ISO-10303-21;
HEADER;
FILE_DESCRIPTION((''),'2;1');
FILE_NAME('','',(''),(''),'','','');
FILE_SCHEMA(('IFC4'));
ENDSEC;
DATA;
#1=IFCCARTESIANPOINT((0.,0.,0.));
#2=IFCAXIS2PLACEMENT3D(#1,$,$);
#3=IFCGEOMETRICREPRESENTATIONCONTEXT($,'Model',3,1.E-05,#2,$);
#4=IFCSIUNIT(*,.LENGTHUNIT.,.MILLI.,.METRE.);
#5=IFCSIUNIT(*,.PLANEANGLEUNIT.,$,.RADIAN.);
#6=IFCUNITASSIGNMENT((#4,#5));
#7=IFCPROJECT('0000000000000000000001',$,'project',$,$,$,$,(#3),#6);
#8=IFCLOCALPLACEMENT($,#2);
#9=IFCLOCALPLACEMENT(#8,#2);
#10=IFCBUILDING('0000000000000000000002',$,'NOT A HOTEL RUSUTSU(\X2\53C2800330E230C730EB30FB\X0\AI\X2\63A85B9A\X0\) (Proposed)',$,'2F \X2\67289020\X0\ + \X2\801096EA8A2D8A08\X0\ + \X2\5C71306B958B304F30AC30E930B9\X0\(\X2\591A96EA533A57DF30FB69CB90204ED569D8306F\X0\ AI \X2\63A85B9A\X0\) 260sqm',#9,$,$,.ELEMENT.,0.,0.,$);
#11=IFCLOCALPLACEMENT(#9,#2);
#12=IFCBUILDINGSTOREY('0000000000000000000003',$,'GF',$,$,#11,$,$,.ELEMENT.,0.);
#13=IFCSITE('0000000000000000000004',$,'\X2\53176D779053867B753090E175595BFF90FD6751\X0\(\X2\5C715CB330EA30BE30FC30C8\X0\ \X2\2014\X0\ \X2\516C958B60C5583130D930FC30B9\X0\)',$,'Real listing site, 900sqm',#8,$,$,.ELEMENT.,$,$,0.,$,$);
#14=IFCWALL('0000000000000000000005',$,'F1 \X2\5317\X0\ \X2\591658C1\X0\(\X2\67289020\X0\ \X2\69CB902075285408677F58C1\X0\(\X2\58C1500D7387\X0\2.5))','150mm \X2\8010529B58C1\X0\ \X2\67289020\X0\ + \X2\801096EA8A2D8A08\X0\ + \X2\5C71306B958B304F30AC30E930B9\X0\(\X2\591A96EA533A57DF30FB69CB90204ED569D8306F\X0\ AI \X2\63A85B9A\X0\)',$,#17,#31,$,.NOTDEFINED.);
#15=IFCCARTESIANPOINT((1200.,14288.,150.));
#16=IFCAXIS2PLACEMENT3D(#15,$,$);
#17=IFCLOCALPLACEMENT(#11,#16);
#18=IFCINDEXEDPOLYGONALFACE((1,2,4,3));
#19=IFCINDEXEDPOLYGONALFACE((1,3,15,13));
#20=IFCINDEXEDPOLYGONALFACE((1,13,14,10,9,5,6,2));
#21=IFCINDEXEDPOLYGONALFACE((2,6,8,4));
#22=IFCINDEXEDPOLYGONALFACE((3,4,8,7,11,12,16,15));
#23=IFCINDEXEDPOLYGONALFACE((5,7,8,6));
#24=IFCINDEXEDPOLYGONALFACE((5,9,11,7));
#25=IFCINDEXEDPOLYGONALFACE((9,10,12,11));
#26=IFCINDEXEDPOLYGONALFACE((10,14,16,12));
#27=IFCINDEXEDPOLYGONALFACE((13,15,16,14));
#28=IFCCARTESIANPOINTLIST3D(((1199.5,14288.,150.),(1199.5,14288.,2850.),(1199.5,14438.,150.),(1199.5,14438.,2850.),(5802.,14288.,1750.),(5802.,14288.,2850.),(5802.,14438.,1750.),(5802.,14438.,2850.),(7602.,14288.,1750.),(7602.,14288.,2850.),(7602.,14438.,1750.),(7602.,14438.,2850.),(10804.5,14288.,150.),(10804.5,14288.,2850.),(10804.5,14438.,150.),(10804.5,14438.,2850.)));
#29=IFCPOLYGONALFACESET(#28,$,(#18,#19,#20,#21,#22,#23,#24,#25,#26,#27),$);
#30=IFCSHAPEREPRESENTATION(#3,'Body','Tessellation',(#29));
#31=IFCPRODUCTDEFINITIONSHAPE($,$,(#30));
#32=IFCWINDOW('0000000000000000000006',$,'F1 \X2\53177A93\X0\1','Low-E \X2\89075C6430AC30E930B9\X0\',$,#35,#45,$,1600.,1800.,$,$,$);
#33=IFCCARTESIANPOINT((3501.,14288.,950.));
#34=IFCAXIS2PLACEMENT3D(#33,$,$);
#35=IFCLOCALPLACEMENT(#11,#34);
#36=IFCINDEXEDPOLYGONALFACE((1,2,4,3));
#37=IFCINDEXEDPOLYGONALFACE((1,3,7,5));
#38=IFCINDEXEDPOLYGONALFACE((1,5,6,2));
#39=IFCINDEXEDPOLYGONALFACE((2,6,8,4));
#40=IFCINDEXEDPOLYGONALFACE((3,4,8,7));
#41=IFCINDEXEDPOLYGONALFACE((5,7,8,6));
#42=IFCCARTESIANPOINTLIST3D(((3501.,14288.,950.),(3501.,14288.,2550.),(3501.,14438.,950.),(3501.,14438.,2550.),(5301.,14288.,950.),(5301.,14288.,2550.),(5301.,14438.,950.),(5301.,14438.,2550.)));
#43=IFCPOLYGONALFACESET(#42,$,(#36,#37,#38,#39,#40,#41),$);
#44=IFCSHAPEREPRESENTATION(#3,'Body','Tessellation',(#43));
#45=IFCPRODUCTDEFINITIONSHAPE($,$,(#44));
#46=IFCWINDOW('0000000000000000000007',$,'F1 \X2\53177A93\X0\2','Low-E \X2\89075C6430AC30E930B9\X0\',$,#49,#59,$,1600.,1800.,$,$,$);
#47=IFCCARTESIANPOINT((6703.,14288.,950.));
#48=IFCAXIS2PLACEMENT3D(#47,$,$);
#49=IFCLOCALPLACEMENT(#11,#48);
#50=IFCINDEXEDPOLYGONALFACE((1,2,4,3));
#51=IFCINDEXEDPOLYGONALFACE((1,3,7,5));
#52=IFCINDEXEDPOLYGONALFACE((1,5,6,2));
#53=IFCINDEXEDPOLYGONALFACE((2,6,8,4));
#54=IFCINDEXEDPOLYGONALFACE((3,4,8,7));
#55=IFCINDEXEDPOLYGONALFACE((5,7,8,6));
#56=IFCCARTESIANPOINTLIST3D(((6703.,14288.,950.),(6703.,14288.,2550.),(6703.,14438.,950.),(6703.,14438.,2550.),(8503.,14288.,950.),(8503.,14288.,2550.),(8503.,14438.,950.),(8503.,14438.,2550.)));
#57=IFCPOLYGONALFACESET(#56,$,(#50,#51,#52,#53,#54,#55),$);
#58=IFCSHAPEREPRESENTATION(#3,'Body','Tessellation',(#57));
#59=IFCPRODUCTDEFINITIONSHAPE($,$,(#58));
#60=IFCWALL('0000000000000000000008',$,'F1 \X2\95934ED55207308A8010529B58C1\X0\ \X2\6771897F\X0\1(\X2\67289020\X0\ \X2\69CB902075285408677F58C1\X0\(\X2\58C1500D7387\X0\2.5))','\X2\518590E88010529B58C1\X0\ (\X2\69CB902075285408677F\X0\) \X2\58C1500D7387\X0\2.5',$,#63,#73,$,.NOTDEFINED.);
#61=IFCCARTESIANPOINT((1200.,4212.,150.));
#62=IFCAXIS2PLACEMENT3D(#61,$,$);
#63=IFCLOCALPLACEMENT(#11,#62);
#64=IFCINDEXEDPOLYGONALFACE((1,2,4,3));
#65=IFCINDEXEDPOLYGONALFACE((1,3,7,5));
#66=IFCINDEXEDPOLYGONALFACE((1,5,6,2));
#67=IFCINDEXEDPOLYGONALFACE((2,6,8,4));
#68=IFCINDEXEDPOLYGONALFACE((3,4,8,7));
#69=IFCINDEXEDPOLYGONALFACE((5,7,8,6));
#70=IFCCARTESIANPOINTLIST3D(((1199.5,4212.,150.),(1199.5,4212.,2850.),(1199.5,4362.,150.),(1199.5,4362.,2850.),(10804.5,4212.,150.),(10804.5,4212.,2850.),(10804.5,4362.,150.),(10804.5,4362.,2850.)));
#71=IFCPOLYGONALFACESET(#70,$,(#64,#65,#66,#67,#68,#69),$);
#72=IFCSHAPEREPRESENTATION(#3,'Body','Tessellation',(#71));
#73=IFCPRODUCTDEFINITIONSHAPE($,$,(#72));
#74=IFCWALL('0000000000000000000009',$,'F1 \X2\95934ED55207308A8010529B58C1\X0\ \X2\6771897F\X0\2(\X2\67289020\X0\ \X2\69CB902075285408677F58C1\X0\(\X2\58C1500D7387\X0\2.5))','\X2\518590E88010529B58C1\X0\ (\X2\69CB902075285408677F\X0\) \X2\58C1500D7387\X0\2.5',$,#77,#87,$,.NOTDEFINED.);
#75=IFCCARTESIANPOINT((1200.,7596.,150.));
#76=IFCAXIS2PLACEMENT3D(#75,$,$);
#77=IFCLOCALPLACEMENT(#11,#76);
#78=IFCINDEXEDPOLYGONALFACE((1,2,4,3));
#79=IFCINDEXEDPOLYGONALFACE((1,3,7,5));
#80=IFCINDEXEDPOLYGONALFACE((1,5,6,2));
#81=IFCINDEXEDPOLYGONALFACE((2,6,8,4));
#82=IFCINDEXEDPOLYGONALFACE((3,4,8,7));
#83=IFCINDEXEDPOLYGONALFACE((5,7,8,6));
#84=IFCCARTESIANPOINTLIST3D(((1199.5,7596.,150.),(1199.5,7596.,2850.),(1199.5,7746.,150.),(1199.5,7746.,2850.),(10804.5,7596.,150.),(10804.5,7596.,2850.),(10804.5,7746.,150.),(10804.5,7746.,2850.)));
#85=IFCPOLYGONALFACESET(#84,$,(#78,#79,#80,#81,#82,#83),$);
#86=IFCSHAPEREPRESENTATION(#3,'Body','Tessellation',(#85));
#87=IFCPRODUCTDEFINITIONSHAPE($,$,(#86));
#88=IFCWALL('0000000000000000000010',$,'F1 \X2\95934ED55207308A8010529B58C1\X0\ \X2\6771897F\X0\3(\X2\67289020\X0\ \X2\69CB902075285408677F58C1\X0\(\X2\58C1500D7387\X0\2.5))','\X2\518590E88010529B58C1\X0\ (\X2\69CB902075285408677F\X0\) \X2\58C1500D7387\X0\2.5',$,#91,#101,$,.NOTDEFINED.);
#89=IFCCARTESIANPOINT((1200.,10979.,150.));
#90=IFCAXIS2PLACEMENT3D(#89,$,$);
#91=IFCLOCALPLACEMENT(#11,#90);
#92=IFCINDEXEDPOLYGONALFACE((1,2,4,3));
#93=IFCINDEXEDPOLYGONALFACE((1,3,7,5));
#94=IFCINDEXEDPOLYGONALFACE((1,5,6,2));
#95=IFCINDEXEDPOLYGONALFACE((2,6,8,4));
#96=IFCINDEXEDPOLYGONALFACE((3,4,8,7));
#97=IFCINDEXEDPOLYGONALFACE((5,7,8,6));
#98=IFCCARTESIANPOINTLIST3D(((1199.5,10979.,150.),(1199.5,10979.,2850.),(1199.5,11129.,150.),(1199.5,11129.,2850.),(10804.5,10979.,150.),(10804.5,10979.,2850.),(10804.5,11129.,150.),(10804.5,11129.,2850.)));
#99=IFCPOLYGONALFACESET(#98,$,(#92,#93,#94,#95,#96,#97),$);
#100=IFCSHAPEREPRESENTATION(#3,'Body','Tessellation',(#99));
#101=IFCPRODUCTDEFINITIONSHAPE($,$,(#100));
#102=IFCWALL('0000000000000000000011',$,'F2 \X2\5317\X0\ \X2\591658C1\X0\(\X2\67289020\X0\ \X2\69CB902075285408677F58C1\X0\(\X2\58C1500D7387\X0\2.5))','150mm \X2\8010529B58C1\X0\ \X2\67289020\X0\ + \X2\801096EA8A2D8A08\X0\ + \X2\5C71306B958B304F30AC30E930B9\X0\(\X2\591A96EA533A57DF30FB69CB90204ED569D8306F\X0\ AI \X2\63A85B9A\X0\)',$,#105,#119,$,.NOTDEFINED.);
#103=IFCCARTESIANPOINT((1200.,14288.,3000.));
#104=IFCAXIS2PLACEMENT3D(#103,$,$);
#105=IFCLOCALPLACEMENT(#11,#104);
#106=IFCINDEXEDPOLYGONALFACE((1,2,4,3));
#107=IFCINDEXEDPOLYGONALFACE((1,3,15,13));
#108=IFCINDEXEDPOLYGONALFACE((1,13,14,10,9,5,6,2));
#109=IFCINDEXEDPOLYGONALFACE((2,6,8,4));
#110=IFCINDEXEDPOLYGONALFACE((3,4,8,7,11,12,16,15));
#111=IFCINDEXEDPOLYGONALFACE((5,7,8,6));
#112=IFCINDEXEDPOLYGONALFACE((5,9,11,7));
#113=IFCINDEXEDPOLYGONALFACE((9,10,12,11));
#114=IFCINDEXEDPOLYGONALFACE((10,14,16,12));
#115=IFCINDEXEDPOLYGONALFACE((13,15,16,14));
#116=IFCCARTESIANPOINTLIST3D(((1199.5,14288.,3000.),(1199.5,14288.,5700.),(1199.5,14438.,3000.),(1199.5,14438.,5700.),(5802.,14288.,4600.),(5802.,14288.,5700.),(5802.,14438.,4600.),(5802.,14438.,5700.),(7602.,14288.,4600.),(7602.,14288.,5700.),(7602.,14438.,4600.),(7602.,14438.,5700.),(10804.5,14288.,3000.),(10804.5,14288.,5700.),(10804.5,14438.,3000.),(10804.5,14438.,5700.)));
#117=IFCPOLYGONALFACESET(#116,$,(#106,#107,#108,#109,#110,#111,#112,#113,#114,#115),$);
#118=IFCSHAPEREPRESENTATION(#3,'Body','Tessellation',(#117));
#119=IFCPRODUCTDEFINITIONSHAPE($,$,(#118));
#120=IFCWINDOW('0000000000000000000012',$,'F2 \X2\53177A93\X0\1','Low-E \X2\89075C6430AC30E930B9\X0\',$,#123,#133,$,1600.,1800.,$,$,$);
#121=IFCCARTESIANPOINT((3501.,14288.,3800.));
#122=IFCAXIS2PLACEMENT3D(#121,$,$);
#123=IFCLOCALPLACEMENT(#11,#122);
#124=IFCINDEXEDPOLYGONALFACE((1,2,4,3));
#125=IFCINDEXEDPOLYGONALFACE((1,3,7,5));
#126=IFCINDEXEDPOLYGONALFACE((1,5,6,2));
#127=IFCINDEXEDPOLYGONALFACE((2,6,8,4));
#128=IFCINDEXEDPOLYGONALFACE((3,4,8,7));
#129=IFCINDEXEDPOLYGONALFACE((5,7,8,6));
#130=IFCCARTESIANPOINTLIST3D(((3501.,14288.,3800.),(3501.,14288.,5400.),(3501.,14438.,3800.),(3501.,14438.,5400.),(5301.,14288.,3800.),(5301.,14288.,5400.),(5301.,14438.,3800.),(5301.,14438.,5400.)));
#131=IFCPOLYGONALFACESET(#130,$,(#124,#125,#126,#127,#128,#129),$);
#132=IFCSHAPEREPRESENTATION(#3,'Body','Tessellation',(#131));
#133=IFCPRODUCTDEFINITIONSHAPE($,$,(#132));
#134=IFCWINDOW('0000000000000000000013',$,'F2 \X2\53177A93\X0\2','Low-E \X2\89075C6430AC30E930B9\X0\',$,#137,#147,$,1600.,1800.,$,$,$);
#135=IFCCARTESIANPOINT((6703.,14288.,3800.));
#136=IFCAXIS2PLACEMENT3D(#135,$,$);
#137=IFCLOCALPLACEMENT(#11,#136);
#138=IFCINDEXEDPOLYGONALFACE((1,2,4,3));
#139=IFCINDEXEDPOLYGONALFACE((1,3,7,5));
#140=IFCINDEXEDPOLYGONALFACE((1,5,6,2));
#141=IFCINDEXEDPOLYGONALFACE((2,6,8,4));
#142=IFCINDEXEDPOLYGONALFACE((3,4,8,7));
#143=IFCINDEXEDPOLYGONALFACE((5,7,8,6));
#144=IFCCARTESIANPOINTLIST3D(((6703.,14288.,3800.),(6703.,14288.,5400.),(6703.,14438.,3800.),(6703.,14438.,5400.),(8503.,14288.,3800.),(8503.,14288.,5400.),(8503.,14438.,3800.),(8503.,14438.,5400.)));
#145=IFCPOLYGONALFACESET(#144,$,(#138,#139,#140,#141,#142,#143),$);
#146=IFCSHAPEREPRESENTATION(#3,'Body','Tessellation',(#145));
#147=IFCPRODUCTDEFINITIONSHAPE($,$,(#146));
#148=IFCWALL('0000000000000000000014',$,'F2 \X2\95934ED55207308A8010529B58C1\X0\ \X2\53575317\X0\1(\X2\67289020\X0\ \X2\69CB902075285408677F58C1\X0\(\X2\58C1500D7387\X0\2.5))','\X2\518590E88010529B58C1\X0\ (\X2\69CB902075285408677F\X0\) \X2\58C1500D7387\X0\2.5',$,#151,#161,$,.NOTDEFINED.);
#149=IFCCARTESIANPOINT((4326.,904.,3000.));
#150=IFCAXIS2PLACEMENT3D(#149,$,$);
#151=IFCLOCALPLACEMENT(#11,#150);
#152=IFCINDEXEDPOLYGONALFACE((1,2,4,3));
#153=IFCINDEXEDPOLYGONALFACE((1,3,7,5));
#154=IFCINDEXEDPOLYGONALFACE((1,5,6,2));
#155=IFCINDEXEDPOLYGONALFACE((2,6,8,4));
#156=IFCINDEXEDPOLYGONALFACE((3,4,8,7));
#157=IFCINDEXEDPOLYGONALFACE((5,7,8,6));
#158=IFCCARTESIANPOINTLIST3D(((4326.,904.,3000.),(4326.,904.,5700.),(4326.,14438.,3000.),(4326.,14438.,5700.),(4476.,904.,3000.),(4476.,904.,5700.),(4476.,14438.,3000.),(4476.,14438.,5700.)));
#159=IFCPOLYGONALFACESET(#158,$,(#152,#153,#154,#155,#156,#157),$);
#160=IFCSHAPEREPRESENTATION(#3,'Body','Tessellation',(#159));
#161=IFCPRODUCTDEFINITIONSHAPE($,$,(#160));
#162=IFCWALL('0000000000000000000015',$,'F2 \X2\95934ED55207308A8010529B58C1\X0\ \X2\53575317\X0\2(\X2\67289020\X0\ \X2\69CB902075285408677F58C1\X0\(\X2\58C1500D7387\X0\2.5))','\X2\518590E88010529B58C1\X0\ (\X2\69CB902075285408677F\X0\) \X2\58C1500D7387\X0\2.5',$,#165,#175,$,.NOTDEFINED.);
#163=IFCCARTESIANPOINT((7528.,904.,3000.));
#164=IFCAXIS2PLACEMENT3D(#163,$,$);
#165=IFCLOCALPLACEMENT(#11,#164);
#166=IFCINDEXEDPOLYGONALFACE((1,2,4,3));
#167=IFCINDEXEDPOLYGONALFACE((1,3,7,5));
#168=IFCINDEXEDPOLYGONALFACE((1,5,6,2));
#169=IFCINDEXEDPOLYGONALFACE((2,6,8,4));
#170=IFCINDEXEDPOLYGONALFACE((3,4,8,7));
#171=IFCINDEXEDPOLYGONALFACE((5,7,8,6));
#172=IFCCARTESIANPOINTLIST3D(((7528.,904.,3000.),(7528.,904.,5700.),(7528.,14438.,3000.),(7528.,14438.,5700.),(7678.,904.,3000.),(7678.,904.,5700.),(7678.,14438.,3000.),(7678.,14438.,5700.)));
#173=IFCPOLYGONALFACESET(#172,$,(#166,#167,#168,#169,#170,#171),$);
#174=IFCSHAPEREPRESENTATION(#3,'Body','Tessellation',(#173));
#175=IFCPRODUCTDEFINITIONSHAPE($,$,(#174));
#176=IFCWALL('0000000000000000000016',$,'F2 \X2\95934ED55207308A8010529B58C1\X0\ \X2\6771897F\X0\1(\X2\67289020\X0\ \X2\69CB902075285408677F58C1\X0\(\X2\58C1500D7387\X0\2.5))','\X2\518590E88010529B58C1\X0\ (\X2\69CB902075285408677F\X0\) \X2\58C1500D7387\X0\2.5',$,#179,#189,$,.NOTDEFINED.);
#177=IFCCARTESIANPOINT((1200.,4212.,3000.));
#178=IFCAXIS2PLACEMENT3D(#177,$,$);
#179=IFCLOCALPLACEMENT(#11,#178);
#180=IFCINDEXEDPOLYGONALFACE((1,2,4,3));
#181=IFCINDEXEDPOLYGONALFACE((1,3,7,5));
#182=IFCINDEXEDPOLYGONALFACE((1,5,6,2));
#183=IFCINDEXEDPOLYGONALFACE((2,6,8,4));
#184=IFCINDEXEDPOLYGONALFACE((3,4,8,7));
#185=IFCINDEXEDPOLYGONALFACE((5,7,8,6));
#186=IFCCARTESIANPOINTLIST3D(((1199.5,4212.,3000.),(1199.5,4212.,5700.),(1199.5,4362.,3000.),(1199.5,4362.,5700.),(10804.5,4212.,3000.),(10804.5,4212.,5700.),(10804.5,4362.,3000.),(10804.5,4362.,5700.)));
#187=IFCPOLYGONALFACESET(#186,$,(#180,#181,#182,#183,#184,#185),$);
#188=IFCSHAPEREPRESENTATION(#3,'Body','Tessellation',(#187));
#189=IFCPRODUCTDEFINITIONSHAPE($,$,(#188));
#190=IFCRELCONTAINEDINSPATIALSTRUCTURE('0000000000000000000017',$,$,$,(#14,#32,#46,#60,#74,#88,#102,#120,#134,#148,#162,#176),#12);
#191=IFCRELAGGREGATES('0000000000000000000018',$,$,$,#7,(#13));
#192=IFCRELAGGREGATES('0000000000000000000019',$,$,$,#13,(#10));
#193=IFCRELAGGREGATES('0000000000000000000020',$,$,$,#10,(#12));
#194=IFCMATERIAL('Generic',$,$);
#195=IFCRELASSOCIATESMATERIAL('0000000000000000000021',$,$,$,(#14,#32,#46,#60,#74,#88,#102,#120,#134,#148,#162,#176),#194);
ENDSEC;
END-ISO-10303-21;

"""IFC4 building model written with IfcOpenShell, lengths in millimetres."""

from ifc_helpers import new_model, si_unit, frame, frame_2d, origin, place, context, project, spatial, rectangle, extrude, material, element, fill, save


model = new_model("IFC4")

# Units and contexts
model_context = context("Model", 3, precision=1e-05, world=origin())
ifc_project = project(units=[si_unit("LENGTHUNIT", "METRE", prefix="MILLI"), si_unit("PLANEANGLEUNIT", "RADIAN")], contexts=[model_context])

# Site, building, storey
site_placement = place(None, origin())
site = spatial("IfcSite", under=ifc_project, at=site_placement, Name="北海道虻田郡留寿都村(山岳リゾート — 公開情報ベース)", ObjectType="Real listing site, 900sqm", CompositionType="ELEMENT", RefElevation=0.0)
building_placement = place(site_placement, origin())
building = spatial("IfcBuilding", under=site, at=building_placement, Name="NOT A HOTEL RUSUTSU(参考モデル・AI推定) (Proposed)", ObjectType="2F 木造 + 耐雪設計 + 山に開くガラス(多雪区域・構造仕様は AI 推定) 260sqm", CompositionType="ELEMENT", ElevationOfRefHeight=0.0, ElevationOfTerrain=0.0)
storey_placement = place(building_placement, origin())
storey = spatial("IfcBuildingStorey", under=building, at=storey_placement, Name="GF", CompositionType="ELEMENT", Elevation=0.0)

# Wall, openings, windows
ifc_material_1 = material(Name="Generic")
wall_1_placement = place(storey_placement, frame((1200.0, 14288.0, 150.0)))
wall_1 = element("IfcWall", 1, at=wall_1_placement, inside=storey, material=ifc_material_1, Name="F1 北 外壁(木造 構造用合板壁(壁倍率2.5))", Description="150mm 耐力壁 木造 + 耐雪設計 + 山に開くガラス(多雪区域・構造仕様は AI 推定)", PredefinedType="NOTDEFINED", context=model_context, shape_type="SweptSolid", body=[
    extrude(rectangle(XDim=9605.0, YDim=150.0, at=frame_2d((4802.0, 75.0))), frame((1200.0, 14288.0, 150.0)), (0.0, 0.0, 1.0), 2700.0),
])
opening_1_placement = place(storey_placement, frame((3501.0, 14288.0, 950.0)))
opening_1 = element("IfcOpeningElement", 2, at=opening_1_placement, cuts=wall_1, PredefinedType="NOTDEFINED", context=model_context, shape_type="SweptSolid", body=[
    extrude(rectangle(XDim=1800.0, YDim=150.0, at=frame_2d((900.0, 75.0))), frame((3501.0, 14288.0, 950.0)), (0.0, 0.0, 1.0), 1600.0),
])
opening_2_placement = place(storey_placement, frame((6703.0, 14288.0, 950.0)))
opening_2 = element("IfcOpeningElement", 3, at=opening_2_placement, cuts=wall_1, PredefinedType="NOTDEFINED", context=model_context, shape_type="SweptSolid", body=[
    extrude(rectangle(XDim=1800.0, YDim=150.0, at=frame_2d((900.0, 75.0))), frame((6703.0, 14288.0, 950.0)), (0.0, 0.0, 1.0), 1600.0),
])
window_1_placement = place(storey_placement, frame((3501.0, 14288.0, 950.0)))
window_1 = element("IfcWindow", 4, at=window_1_placement, inside=storey, material=ifc_material_1, Name="F1 北窓1", Description="Low-E 複層ガラス", OverallHeight=1600.0, OverallWidth=1800.0, context=model_context, shape_type="SweptSolid", body=[
    extrude(rectangle(XDim=1800.0, YDim=150.0, at=frame_2d((900.0, 75.0))), frame((3501.0, 14288.0, 950.0)), (0.0, 0.0, 1.0), 1600.0),
])
fill(opening_1, window_1)
window_2_placement = place(storey_placement, frame((6703.0, 14288.0, 950.0)))
window_2 = element("IfcWindow", 5, at=window_2_placement, inside=storey, material=ifc_material_1, Name="F1 北窓2", Description="Low-E 複層ガラス", OverallHeight=1600.0, OverallWidth=1800.0, context=model_context, shape_type="SweptSolid", body=[
    extrude(rectangle(XDim=1800.0, YDim=150.0, at=frame_2d((900.0, 75.0))), frame((6703.0, 14288.0, 950.0)), (0.0, 0.0, 1.0), 1600.0),
])
fill(opening_2, window_2)

# Walls
wall_2_placement = place(storey_placement, frame((1200.0, 4212.0, 150.0)))
element("IfcWall", 6, at=wall_2_placement, inside=storey, material=ifc_material_1, Name="F1 間仕切り耐力壁 東西1(木造 構造用合板壁(壁倍率2.5))", Description="内部耐力壁 (構造用合板) 壁倍率2.5", PredefinedType="NOTDEFINED", context=model_context, shape_type="SweptSolid", body=[
    extrude(rectangle(XDim=9605.0, YDim=150.0, at=frame_2d((4802.0, 75.0))), frame((1200.0, 4212.0, 150.0)), (0.0, 0.0, 1.0), 2700.0),
])
wall_3_placement = place(storey_placement, frame((1200.0, 7596.0, 150.0)))
element("IfcWall", 7, at=wall_3_placement, inside=storey, material=ifc_material_1, Name="F1 間仕切り耐力壁 東西2(木造 構造用合板壁(壁倍率2.5))", Description="内部耐力壁 (構造用合板) 壁倍率2.5", PredefinedType="NOTDEFINED", context=model_context, shape_type="SweptSolid", body=[
    extrude(rectangle(XDim=9605.0, YDim=150.0, at=frame_2d((4802.0, 75.0))), frame((1200.0, 7596.0, 150.0)), (0.0, 0.0, 1.0), 2700.0),
])
wall_4_placement = place(storey_placement, frame((1200.0, 10979.0, 150.0)))
element("IfcWall", 8, at=wall_4_placement, inside=storey, material=ifc_material_1, Name="F1 間仕切り耐力壁 東西3(木造 構造用合板壁(壁倍率2.5))", Description="内部耐力壁 (構造用合板) 壁倍率2.5", PredefinedType="NOTDEFINED", context=model_context, shape_type="SweptSolid", body=[
    extrude(rectangle(XDim=9605.0, YDim=150.0, at=frame_2d((4802.0, 75.0))), frame((1200.0, 10979.0, 150.0)), (0.0, 0.0, 1.0), 2700.0),
])

# Wall, openings, windows
wall_5_placement = place(storey_placement, frame((1200.0, 14288.0, 3000.0)))
wall_5 = element("IfcWall", 9, at=wall_5_placement, inside=storey, material=ifc_material_1, Name="F2 北 外壁(木造 構造用合板壁(壁倍率2.5))", Description="150mm 耐力壁 木造 + 耐雪設計 + 山に開くガラス(多雪区域・構造仕様は AI 推定)", PredefinedType="NOTDEFINED", context=model_context, shape_type="SweptSolid", body=[
    extrude(rectangle(XDim=9605.0, YDim=150.0, at=frame_2d((4802.0, 75.0))), frame((1200.0, 14288.0, 3000.0)), (0.0, 0.0, 1.0), 2700.0),
])
opening_3_placement = place(storey_placement, frame((3501.0, 14288.0, 3800.0)))
opening_3 = element("IfcOpeningElement", 10, at=opening_3_placement, cuts=wall_5, PredefinedType="NOTDEFINED", context=model_context, shape_type="SweptSolid", body=[
    extrude(rectangle(XDim=1800.0, YDim=150.0, at=frame_2d((900.0, 75.0))), frame((3501.0, 14288.0, 3800.0)), (0.0, 0.0, 1.0), 1600.0),
])
opening_4_placement = place(storey_placement, frame((6703.0, 14288.0, 3800.0)))
opening_4 = element("IfcOpeningElement", 11, at=opening_4_placement, cuts=wall_5, PredefinedType="NOTDEFINED", context=model_context, shape_type="SweptSolid", body=[
    extrude(rectangle(XDim=1800.0, YDim=150.0, at=frame_2d((900.0, 75.0))), frame((6703.0, 14288.0, 3800.0)), (0.0, 0.0, 1.0), 1600.0),
])
window_3_placement = place(storey_placement, frame((3501.0, 14288.0, 3800.0)))
window_3 = element("IfcWindow", 12, at=window_3_placement, inside=storey, material=ifc_material_1, Name="F2 北窓1", Description="Low-E 複層ガラス", OverallHeight=1600.0, OverallWidth=1800.0, context=model_context, shape_type="SweptSolid", body=[
    extrude(rectangle(XDim=1800.0, YDim=150.0, at=frame_2d((900.0, 75.0))), frame((3501.0, 14288.0, 3800.0)), (0.0, 0.0, 1.0), 1600.0),
])
fill(opening_3, window_3)
window_4_placement = place(storey_placement, frame((6703.0, 14288.0, 3800.0)))
window_4 = element("IfcWindow", 13, at=window_4_placement, inside=storey, material=ifc_material_1, Name="F2 北窓2", Description="Low-E 複層ガラス", OverallHeight=1600.0, OverallWidth=1800.0, context=model_context, shape_type="SweptSolid", body=[
    extrude(rectangle(XDim=1800.0, YDim=150.0, at=frame_2d((900.0, 75.0))), frame((6703.0, 14288.0, 3800.0)), (0.0, 0.0, 1.0), 1600.0),
])
fill(opening_4, window_4)

# Walls
wall_6_placement = place(storey_placement, frame((4326.0, 904.0, 3000.0)))
element("IfcWall", 14, at=wall_6_placement, inside=storey, material=ifc_material_1, Name="F2 間仕切り耐力壁 南北1(木造 構造用合板壁(壁倍率2.5))", Description="内部耐力壁 (構造用合板) 壁倍率2.5", PredefinedType="NOTDEFINED", context=model_context, shape_type="SweptSolid", body=[
    extrude(rectangle(XDim=150.0, YDim=13534.0, at=frame_2d((75.0, 6767.0))), frame((4326.0, 904.0, 3000.0)), (0.0, 0.0, 1.0), 2700.0),
])
wall_7_placement = place(storey_placement, frame((7528.0, 904.0, 3000.0)))
element("IfcWall", 15, at=wall_7_placement, inside=storey, material=ifc_material_1, Name="F2 間仕切り耐力壁 南北2(木造 構造用合板壁(壁倍率2.5))", Description="内部耐力壁 (構造用合板) 壁倍率2.5", PredefinedType="NOTDEFINED", context=model_context, shape_type="SweptSolid", body=[
    extrude(rectangle(XDim=150.0, YDim=13534.0, at=frame_2d((75.0, 6767.0))), frame((7528.0, 904.0, 3000.0)), (0.0, 0.0, 1.0), 2700.0),
])
wall_8_placement = place(storey_placement, frame((1200.0, 4212.0, 3000.0)))
element("IfcWall", 16, at=wall_8_placement, inside=storey, material=ifc_material_1, Name="F2 間仕切り耐力壁 東西1(木造 構造用合板壁(壁倍率2.5))", Description="内部耐力壁 (構造用合板) 壁倍率2.5", PredefinedType="NOTDEFINED", context=model_context, shape_type="SweptSolid", body=[
    extrude(rectangle(XDim=9605.0, YDim=150.0, at=frame_2d((4802.0, 75.0))), frame((1200.0, 4212.0, 3000.0)), (0.0, 0.0, 1.0), 2700.0),
])

save(model, "model.ifc")
